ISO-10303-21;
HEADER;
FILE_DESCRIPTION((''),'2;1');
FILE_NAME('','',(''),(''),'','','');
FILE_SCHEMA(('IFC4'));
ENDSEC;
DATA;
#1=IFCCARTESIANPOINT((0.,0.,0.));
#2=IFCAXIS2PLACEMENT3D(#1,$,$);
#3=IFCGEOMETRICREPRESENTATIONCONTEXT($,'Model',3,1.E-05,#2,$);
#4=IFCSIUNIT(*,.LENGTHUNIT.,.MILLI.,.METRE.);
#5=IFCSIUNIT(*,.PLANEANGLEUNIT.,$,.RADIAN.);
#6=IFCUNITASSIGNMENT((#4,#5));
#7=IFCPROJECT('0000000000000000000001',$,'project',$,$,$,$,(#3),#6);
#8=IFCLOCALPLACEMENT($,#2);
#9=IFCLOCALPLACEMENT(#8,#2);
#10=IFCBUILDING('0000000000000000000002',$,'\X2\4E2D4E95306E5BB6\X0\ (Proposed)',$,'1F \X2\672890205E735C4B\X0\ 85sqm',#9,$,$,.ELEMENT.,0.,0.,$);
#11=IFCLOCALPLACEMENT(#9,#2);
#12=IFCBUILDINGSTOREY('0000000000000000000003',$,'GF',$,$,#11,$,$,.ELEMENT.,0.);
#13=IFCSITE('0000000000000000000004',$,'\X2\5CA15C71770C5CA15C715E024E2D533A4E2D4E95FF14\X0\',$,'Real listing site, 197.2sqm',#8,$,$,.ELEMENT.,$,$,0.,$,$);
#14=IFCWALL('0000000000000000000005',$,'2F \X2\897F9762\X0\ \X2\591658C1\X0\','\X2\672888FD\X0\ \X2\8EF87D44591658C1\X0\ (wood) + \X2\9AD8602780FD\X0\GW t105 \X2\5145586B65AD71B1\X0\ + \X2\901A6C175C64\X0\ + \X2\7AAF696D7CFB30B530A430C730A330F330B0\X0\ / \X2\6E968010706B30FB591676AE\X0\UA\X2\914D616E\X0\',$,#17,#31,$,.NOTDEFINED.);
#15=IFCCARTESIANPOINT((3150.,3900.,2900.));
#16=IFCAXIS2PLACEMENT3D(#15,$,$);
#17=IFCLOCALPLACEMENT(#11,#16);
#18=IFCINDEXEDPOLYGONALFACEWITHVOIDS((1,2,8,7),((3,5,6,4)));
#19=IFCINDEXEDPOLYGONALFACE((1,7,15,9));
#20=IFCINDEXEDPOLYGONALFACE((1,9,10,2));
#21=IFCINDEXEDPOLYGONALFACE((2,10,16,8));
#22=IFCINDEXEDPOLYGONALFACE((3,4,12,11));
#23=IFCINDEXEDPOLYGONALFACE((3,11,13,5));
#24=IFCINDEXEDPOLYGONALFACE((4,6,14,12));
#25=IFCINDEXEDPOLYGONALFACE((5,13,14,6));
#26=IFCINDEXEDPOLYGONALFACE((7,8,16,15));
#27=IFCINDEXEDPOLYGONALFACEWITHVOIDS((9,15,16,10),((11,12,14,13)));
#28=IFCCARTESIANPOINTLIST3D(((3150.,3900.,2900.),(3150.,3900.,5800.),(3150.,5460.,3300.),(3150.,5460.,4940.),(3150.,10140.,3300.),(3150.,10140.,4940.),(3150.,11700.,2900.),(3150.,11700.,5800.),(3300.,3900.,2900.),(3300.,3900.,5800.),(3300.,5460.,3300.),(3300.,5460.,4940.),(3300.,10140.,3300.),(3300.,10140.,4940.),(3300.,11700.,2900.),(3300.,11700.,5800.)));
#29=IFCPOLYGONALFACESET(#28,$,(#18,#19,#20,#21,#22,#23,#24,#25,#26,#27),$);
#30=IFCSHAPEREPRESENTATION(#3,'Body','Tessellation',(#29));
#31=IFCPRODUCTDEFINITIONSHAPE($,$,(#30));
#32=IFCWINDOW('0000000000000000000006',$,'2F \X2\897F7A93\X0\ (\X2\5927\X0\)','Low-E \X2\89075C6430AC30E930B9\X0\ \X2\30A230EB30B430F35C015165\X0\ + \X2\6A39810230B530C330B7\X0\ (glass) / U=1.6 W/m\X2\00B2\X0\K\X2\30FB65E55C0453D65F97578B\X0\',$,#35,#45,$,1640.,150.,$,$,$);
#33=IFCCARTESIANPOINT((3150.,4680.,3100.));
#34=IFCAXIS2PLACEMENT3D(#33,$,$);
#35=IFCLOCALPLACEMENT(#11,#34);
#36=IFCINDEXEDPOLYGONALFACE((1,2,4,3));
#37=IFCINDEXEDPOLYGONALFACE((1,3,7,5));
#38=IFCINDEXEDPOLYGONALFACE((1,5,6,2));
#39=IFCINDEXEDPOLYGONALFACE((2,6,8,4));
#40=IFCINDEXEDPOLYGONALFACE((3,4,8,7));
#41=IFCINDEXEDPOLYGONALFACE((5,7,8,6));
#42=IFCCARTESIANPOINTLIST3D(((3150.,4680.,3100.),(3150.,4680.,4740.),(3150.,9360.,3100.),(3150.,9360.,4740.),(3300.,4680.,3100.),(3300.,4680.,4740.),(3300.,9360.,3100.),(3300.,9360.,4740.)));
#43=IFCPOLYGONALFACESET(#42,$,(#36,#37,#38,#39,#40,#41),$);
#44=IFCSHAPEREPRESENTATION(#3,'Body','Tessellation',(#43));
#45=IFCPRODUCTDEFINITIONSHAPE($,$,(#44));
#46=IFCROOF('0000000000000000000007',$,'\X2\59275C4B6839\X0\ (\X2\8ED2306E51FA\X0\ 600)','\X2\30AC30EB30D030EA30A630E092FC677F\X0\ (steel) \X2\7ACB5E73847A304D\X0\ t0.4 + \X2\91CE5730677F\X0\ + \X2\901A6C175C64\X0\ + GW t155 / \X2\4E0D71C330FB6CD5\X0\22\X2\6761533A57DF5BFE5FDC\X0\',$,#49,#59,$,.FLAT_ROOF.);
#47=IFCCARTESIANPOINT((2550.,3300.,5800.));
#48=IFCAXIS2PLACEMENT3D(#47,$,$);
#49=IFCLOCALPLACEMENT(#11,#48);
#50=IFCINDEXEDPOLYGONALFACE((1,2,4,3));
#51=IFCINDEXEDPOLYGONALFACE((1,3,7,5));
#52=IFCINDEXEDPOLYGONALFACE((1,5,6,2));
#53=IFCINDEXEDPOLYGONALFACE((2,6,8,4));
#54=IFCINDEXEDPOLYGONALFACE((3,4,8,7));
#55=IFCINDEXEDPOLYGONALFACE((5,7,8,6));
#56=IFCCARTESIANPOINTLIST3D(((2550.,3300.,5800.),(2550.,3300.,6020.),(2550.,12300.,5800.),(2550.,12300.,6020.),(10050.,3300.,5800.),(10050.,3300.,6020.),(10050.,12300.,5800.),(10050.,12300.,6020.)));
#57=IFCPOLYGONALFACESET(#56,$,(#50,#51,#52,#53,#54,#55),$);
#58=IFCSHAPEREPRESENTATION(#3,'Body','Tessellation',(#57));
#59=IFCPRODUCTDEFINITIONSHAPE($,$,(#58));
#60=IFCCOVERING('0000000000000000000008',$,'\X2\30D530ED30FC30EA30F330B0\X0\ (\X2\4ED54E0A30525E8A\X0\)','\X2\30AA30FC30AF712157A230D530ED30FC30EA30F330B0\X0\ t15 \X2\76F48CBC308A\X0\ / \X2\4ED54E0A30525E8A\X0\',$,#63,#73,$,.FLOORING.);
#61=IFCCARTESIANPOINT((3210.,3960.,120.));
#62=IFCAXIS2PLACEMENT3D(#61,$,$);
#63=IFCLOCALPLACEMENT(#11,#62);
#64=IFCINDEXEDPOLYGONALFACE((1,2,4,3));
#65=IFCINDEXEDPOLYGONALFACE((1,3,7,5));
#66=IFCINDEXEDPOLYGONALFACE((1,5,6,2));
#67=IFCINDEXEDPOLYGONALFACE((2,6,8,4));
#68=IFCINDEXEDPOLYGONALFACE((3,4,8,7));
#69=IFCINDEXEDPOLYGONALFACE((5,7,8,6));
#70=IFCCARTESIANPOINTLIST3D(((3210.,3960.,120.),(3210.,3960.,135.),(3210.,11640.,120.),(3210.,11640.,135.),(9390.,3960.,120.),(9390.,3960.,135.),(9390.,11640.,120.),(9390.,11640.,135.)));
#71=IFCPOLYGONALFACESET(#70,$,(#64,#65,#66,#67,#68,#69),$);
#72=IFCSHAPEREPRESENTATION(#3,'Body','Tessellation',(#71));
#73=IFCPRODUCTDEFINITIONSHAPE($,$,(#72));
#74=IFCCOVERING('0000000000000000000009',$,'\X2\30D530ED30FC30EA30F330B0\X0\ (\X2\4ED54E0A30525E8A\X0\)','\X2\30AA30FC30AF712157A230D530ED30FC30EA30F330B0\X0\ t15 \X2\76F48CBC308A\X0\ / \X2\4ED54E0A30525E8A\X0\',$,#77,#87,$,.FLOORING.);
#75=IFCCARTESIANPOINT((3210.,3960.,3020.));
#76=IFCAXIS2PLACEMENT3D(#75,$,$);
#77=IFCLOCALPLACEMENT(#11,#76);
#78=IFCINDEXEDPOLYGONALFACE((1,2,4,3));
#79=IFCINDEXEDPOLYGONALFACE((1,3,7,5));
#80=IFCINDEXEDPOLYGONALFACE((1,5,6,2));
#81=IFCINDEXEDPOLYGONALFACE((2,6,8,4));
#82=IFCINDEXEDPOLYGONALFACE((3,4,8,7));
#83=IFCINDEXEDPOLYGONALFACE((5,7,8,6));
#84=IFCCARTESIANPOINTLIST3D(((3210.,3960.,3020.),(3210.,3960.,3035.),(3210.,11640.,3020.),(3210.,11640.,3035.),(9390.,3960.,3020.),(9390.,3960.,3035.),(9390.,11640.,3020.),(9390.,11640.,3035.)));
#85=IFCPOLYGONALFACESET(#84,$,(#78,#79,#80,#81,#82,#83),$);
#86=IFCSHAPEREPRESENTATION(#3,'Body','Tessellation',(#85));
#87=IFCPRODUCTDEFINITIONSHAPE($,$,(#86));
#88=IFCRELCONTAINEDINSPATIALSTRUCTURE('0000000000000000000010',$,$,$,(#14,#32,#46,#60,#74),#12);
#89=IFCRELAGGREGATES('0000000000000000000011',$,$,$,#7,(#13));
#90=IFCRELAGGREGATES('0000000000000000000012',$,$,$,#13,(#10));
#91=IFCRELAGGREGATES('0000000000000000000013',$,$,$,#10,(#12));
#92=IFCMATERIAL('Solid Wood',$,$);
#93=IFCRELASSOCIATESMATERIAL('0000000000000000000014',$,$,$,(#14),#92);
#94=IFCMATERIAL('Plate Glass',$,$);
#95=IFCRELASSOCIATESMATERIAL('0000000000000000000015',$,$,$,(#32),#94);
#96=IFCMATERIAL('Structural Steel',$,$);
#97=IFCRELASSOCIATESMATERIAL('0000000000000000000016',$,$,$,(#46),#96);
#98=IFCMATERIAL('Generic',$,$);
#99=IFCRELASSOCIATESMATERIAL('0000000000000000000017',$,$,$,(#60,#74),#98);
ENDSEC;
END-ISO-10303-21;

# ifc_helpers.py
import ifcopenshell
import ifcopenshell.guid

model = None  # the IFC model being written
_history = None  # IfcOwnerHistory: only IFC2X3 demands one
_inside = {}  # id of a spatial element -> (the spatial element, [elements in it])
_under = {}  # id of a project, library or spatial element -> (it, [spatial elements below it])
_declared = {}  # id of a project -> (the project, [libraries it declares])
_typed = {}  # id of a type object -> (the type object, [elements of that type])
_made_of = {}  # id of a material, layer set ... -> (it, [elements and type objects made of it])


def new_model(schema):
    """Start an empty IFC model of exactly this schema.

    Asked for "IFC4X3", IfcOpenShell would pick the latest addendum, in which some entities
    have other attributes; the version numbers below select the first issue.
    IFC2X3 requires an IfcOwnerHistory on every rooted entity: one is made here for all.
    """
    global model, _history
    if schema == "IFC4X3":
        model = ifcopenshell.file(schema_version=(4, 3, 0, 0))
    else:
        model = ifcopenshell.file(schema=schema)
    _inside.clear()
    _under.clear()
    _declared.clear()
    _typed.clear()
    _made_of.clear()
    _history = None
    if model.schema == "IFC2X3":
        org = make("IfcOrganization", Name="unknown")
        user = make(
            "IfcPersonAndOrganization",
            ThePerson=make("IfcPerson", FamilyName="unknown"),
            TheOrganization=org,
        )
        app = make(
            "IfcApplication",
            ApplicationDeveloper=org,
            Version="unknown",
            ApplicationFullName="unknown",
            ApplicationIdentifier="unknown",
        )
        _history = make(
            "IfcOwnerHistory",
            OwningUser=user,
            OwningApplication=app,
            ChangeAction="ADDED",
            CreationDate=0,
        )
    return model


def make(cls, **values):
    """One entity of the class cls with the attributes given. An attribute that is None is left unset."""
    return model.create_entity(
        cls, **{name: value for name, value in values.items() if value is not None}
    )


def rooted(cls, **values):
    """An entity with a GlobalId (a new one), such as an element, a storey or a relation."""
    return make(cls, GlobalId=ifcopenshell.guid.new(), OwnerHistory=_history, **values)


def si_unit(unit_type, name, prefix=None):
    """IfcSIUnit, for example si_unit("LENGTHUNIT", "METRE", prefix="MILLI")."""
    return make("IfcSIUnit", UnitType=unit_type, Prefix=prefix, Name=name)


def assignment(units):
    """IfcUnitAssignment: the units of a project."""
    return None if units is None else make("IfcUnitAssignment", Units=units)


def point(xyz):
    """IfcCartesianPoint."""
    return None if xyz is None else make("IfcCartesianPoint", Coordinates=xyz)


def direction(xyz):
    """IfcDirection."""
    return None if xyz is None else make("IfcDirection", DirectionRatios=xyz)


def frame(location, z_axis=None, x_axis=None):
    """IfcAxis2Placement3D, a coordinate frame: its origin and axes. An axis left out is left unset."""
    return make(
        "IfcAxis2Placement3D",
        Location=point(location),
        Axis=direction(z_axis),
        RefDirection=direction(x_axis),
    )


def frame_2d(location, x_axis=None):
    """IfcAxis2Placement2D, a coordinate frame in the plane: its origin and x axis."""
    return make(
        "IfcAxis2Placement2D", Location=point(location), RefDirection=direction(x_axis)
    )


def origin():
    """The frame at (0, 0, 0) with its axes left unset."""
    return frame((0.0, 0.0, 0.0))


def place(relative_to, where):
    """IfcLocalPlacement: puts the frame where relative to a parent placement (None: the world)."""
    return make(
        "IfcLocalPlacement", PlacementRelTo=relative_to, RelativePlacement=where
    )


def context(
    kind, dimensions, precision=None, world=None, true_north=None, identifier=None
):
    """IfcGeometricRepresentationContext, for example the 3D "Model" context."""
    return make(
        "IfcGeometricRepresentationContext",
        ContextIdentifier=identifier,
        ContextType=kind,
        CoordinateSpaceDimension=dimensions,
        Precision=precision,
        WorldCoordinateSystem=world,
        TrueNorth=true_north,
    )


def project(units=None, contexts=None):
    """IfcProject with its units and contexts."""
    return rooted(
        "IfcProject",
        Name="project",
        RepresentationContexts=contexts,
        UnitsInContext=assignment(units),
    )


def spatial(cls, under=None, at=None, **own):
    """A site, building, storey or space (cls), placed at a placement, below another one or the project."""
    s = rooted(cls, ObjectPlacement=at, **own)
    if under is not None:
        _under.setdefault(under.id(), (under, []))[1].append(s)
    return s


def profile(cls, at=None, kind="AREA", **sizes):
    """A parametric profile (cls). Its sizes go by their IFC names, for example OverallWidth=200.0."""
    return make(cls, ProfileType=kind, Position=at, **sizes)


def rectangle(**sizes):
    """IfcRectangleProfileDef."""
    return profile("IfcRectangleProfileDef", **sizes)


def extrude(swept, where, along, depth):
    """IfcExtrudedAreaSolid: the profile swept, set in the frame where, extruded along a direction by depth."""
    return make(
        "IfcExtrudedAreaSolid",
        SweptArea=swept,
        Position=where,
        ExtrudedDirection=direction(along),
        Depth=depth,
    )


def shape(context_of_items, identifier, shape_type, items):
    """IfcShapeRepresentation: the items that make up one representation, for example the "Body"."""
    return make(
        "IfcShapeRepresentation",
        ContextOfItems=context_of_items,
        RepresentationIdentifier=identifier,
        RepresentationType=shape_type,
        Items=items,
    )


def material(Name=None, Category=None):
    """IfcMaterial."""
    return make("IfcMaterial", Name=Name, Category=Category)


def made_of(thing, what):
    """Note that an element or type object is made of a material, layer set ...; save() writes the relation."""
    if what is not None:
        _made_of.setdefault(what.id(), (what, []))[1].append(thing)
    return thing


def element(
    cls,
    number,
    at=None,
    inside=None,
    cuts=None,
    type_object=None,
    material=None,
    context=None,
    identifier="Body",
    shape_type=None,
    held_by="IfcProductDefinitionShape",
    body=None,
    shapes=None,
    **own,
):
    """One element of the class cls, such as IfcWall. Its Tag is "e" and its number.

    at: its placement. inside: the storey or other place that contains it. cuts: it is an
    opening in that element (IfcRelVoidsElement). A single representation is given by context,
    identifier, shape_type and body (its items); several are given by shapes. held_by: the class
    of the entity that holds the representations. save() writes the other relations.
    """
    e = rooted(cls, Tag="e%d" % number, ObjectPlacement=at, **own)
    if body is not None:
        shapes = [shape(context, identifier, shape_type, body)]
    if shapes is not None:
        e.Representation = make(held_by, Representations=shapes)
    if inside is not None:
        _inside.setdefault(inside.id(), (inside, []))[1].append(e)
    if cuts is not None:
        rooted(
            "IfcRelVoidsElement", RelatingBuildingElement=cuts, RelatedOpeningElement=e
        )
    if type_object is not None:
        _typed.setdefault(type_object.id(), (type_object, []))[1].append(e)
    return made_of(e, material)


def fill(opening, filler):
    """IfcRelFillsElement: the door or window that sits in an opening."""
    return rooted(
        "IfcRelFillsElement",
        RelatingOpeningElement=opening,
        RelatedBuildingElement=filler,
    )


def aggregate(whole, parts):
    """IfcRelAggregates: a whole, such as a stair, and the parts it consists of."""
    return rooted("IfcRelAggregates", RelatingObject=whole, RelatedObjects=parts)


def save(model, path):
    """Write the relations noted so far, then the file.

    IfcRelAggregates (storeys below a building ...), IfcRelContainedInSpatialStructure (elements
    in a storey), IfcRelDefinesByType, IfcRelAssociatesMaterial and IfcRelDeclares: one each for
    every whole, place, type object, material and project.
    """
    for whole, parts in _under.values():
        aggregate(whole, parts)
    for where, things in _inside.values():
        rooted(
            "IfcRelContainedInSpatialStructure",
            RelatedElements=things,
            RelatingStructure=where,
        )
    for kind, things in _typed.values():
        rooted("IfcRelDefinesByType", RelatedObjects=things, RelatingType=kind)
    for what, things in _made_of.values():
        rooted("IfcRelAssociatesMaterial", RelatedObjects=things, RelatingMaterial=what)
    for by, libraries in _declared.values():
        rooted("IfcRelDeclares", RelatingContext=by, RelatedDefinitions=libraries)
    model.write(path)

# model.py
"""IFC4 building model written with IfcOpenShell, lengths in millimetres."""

from ifc_helpers import new_model, si_unit, frame, frame_2d, origin, place, context, project, spatial, rectangle, extrude, material, element, fill, save


model = new_model("IFC4")

# Units and contexts
model_context = context("Model", 3, precision=1e-05, world=origin())
ifc_project = project(units=[si_unit("LENGTHUNIT", "METRE", prefix="MILLI"), si_unit("PLANEANGLEUNIT", "RADIAN")], contexts=[model_context])

# Site, building, storey
site_placement = place(None, origin())
site = spatial("IfcSite", under=ifc_project, at=site_placement, Name="岡山県岡山市中区中井４", ObjectType="Real listing site, 197.2sqm", CompositionType="ELEMENT", RefElevation=0.0)
building_placement = place(site_placement, origin())
building = spatial("IfcBuilding", under=site, at=building_placement, Name="中井の家 (Proposed)", ObjectType="1F 木造平屋 85sqm", CompositionType="ELEMENT", ElevationOfRefHeight=0.0, ElevationOfTerrain=0.0)
storey_placement = place(building_placement, origin())
storey = spatial("IfcBuildingStorey", under=building, at=storey_placement, Name="GF", CompositionType="ELEMENT", Elevation=0.0)

# Shared definitions
ifc_material_1 = material(Name="Solid Wood")
ifc_material_2 = material(Name="Generic")

# Shared definitions
ifc_material_3 = material(Name="Plate Glass")

# Wall, opening, window
wall_1_placement = place(storey_placement, frame((3150.0, 3900.0, 2900.0)))
wall_1 = element("IfcWall", 1, at=wall_1_placement, inside=storey, material=ifc_material_1, Name="2F 西面 外壁", Description="木製 軸組外壁 (wood) + 高性能GW t105 充填断熱 + 通気層 + 窯業系サイディング / 準耐火・外皮UA配慮", PredefinedType="NOTDEFINED", context=model_context, shape_type="SweptSolid", body=[
    extrude(rectangle(XDim=150.0, YDim=7800.0, at=frame_2d((75.0, 3900.0))), frame((3150.0, 3900.0, 2900.0)), (0.0, 0.0, 1.0), 2900.0),
])
opening_1_placement = place(storey_placement, frame((3150.0, 4680.0, 3100.0)))
opening_1 = element("IfcOpeningElement", 2, at=opening_1_placement, cuts=wall_1, PredefinedType="NOTDEFINED", context=model_context, shape_type="SweptSolid", body=[
    extrude(rectangle(XDim=150.0, YDim=4680.0, at=frame_2d((75.0, 2340.0))), frame((3150.0, 4680.0, 3100.0)), (0.0, 0.0, 1.0), 1640.0),
])
window_1_placement = place(storey_placement, frame((3150.0, 4680.0, 3100.0)))
window_1 = element("IfcWindow", 3, at=window_1_placement, inside=storey, material=ifc_material_3, Name="2F 西窓 (大)", Description="Low-E 複層ガラス アルゴン封入 + 樹脂サッシ (glass) / U=1.6 W/m²K・日射取得型", OverallHeight=1640.0, OverallWidth=150.0, context=model_context, shape_type="SweptSolid", body=[
    extrude(rectangle(XDim=150.0, YDim=4680.0, at=frame_2d((75.0, 2340.0))), frame((3150.0, 4680.0, 3100.0)), (0.0, 0.0, 1.0), 1640.0),
])
fill(opening_1, window_1)

# Roof
ifc_material_4 = material(Name="Structural Steel")
roof_placement = place(storey_placement, frame((2550.0, 3300.0, 5800.0)))
element("IfcRoof", 4, at=roof_placement, inside=storey, material=ifc_material_4, Name="大屋根 (軒の出 600)", Description="ガルバリウム鋼板 (steel) 立平葺き t0.4 + 野地板 + 通気層 + GW t155 / 不燃・法22条区域対応", PredefinedType="FLAT_ROOF", context=model_context, shape_type="SweptSolid", body=[
    extrude(rectangle(XDim=7500.0, YDim=9000.0, at=frame_2d((3750.0, 4500.0))), frame((2550.0, 3300.0, 5800.0)), (0.0, 0.0, 1.0), 220.0),
])

# Coverings
covering_1_placement = place(storey_placement, frame((3210.0, 3960.0, 120.0)))
element("IfcCovering", 5, at=covering_1_placement, inside=storey, material=ifc_material_2, Name="フローリング (仕上げ床)", Description="オーク無垢フローリング t15 直貼り / 仕上げ床", PredefinedType="FLOORING", context=model_context, shape_type="SweptSolid", body=[
    extrude(rectangle(XDim=6180.0, YDim=7680.0, at=frame_2d((3090.0, 3840.0))), frame((3210.0, 3960.0, 120.0)), (0.0, 0.0, 1.0), 15.0),
])
covering_2_placement = place(storey_placement, frame((3210.0, 3960.0, 3020.0)))
element("IfcCovering", 6, at=covering_2_placement, inside=storey, material=ifc_material_2, Name="フローリング (仕上げ床)", Description="オーク無垢フローリング t15 直貼り / 仕上げ床", PredefinedType="FLOORING", context=model_context, shape_type="SweptSolid", body=[
    extrude(rectangle(XDim=6180.0, YDim=7680.0, at=frame_2d((3090.0, 3840.0))), frame((3210.0, 3960.0, 3020.0)), (0.0, 0.0, 1.0), 15.0),
])

save(model, "model.ifc")
